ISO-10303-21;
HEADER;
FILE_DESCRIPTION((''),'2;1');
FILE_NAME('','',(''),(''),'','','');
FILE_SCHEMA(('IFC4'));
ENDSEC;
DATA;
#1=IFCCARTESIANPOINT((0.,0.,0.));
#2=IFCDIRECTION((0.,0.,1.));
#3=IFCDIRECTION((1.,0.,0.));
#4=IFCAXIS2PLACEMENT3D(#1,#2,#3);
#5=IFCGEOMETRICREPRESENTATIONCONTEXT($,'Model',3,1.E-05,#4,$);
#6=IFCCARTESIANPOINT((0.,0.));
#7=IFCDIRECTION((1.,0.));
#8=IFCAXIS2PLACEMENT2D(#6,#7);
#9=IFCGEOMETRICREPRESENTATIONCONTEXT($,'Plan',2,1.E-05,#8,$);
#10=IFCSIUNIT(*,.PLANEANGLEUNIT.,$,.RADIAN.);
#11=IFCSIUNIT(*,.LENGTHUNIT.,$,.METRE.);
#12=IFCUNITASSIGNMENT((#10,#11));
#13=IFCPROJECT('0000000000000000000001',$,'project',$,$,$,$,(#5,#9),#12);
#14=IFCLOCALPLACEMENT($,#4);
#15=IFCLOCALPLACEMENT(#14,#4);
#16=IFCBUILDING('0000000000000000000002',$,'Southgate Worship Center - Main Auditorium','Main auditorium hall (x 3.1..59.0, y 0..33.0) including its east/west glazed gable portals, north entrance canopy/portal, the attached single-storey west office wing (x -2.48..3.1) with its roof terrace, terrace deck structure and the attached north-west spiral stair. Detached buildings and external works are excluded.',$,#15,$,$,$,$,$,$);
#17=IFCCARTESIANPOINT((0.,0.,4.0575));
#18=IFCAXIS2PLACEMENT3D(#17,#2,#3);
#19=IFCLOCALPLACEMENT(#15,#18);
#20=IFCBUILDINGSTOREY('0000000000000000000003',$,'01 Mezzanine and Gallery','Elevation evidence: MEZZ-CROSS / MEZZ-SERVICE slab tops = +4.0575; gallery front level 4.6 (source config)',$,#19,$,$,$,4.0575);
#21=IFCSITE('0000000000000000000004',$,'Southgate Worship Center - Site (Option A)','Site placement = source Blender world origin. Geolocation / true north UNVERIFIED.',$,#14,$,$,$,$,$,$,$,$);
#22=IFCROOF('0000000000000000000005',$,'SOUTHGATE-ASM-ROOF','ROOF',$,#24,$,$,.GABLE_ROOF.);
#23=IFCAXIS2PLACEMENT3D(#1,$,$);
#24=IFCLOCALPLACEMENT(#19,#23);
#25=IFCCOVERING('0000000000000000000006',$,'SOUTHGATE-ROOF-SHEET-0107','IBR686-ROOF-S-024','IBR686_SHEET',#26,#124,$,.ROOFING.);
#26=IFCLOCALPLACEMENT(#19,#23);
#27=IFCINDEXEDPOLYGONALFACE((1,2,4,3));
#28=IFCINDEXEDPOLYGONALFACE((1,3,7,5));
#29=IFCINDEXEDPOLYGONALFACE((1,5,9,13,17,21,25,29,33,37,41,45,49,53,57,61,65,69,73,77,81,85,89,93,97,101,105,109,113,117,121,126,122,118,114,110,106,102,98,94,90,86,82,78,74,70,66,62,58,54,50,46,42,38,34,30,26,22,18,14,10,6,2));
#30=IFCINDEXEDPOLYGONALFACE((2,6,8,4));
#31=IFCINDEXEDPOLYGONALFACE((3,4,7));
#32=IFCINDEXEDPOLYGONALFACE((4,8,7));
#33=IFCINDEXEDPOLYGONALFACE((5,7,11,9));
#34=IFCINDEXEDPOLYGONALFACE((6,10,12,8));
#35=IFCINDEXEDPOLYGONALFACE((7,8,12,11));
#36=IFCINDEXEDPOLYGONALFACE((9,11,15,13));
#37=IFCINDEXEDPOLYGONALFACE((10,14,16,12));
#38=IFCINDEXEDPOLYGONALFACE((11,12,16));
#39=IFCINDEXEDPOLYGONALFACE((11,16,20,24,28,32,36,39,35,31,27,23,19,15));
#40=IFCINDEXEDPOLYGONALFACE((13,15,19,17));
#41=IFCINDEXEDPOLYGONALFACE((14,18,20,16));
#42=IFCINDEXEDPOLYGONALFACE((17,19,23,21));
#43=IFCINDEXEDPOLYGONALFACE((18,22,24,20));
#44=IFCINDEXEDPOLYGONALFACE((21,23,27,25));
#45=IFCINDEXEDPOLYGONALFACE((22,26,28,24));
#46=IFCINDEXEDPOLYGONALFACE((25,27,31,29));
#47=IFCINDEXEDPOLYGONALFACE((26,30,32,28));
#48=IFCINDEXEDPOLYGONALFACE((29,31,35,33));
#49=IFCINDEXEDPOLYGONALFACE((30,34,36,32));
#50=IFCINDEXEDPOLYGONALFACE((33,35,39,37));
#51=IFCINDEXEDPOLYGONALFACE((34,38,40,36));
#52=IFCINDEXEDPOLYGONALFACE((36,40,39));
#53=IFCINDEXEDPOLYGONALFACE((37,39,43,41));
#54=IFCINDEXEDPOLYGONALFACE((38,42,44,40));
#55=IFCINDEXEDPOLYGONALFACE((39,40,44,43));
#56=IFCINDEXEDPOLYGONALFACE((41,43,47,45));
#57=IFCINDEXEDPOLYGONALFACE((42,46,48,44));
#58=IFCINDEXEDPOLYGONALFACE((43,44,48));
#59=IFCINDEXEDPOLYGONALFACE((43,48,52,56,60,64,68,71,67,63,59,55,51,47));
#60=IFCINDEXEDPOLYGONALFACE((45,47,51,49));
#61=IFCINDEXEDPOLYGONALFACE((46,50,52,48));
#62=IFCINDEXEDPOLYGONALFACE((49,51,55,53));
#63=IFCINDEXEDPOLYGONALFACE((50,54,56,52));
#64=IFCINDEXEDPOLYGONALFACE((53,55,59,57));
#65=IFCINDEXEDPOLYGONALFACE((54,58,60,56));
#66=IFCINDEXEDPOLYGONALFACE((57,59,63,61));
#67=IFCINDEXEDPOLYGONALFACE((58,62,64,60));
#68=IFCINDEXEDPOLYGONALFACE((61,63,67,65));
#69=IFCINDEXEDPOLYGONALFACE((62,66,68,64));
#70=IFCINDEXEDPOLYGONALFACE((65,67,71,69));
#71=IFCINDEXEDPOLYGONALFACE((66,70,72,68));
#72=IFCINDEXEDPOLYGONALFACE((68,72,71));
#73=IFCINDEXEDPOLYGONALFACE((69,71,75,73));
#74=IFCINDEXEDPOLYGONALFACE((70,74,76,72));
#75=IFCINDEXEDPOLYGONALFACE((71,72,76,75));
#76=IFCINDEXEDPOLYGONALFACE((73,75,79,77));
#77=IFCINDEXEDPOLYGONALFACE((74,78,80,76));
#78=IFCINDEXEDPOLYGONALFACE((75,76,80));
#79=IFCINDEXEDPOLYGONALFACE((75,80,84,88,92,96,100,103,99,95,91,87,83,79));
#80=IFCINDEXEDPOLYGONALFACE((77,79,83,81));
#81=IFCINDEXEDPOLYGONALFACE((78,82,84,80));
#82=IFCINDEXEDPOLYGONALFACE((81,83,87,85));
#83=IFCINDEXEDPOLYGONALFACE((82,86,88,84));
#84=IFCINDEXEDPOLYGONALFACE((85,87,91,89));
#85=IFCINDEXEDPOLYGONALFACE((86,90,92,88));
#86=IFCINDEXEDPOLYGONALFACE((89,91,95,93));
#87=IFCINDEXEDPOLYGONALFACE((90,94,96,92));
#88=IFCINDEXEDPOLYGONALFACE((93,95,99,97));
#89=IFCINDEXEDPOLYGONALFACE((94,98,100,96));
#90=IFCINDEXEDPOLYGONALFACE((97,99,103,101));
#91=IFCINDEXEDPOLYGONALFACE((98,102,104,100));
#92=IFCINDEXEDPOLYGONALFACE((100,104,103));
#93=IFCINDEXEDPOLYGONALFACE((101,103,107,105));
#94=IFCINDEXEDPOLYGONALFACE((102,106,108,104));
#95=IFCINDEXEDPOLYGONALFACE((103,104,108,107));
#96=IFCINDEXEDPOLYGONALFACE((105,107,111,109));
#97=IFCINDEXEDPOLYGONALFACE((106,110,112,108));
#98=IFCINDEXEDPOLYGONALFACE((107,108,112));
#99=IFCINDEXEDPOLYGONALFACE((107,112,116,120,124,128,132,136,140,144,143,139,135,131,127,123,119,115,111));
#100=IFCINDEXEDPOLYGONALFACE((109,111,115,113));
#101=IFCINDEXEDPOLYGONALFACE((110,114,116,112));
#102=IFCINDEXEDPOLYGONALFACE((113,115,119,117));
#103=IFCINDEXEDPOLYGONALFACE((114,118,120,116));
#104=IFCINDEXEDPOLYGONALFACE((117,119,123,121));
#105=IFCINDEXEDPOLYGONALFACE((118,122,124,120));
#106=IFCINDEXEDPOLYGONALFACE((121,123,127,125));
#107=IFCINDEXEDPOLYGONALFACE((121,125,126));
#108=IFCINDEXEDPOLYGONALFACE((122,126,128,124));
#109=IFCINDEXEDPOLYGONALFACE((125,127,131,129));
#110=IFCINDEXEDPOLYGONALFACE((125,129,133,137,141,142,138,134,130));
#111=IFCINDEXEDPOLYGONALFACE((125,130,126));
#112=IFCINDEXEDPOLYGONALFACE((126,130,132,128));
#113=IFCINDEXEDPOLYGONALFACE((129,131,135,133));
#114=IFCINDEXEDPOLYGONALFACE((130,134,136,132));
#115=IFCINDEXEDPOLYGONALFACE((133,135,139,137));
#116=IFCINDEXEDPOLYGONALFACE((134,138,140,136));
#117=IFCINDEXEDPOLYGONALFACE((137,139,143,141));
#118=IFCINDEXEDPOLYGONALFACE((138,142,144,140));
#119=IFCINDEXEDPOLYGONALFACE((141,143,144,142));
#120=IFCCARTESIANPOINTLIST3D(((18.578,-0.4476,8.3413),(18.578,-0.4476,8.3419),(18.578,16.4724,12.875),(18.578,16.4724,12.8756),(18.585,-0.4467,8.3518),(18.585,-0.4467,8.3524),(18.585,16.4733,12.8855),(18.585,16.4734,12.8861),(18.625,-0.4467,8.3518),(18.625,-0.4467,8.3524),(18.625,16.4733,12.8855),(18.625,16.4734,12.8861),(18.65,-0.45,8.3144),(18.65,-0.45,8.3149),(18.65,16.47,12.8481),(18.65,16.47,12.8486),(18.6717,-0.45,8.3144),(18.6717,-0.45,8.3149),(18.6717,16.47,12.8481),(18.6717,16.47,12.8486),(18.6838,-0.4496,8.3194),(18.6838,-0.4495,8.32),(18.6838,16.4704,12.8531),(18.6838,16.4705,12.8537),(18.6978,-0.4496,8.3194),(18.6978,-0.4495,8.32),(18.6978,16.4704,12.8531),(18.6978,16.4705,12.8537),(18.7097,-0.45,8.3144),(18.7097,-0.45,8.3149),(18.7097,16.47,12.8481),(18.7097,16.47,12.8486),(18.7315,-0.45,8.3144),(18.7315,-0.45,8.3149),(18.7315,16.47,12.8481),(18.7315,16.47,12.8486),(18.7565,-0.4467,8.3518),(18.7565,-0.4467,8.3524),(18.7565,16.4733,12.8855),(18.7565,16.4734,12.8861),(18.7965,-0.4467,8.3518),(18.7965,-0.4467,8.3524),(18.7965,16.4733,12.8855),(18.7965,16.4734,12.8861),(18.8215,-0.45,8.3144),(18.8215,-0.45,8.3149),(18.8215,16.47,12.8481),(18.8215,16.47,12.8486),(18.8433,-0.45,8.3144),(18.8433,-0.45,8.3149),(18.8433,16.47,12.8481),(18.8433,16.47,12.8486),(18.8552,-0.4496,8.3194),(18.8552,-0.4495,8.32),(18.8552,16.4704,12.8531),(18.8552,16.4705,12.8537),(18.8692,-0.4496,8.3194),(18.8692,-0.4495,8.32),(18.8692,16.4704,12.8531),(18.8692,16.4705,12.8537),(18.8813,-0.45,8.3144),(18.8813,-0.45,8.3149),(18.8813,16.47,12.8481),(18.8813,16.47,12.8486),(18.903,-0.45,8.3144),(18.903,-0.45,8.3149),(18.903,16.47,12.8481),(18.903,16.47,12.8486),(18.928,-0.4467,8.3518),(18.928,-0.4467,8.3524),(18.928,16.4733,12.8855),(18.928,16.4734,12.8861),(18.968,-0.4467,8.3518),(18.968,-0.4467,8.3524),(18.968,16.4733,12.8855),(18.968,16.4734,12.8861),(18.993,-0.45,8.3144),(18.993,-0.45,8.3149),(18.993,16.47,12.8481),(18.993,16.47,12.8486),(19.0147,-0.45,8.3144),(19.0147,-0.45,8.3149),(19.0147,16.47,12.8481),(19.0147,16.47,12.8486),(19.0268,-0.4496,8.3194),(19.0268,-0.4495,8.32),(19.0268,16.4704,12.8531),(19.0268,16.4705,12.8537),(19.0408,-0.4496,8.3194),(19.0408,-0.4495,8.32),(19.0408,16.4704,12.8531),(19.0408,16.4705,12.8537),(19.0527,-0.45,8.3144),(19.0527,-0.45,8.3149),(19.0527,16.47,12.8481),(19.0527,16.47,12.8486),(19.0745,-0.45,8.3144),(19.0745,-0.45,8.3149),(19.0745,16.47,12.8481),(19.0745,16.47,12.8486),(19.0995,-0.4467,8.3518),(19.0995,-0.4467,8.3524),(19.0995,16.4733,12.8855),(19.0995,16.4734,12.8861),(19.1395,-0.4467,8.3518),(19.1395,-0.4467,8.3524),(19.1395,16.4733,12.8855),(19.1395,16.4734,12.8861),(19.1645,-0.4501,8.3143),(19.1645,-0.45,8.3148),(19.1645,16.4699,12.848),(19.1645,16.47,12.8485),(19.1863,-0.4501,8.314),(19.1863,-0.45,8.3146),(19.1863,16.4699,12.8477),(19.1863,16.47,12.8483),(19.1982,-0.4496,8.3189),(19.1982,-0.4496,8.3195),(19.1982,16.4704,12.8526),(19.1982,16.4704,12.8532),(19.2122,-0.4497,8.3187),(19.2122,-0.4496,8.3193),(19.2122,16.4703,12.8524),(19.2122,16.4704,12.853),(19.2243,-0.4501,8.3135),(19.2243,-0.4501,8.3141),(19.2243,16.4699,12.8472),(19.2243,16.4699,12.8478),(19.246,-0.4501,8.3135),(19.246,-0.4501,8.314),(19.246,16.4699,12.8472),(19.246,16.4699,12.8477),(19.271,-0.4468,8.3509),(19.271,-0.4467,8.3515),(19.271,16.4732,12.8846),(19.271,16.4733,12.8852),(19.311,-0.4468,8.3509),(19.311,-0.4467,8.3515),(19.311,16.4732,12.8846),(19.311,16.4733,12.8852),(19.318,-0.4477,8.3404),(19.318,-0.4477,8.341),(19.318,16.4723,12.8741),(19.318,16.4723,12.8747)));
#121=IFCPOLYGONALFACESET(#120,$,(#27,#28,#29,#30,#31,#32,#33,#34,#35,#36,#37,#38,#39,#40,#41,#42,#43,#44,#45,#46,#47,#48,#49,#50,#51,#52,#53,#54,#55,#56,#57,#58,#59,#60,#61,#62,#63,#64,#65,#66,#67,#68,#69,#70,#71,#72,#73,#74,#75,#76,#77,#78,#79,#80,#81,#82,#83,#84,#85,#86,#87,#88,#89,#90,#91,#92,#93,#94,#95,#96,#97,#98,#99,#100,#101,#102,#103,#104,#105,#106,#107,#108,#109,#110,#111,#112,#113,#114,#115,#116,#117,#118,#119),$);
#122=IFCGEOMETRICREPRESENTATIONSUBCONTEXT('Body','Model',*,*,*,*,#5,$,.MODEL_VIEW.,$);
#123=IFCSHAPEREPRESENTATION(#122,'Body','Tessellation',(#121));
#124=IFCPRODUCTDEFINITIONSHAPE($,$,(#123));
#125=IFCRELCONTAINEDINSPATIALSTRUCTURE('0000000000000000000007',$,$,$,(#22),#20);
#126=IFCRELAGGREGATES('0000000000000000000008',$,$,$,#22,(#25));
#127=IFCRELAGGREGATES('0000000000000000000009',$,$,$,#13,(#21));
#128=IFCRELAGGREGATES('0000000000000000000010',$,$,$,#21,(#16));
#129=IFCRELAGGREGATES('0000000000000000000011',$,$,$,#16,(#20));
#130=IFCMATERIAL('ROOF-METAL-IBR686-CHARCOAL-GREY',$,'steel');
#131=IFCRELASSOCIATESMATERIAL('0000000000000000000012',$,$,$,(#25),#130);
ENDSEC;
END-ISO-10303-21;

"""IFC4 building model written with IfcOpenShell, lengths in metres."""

from ifc_helpers import new_model, si_unit, frame, origin_with_axes, origin_2d_with_axis, place, context, subcontext, project, spatial, indexed_curve, outline, extrude, clip, halfspace, material, element, aggregate, save


model = new_model("IFC4")

# Units and contexts
model_context = context("Model", 3, precision=1e-05, world=origin_with_axes())
plan_context = context("Plan", 2, precision=1e-05, world=origin_2d_with_axis())
body_context = subcontext(model_context, "Body", "Model", "MODEL_VIEW")
ifc_project = project(units=[si_unit("PLANEANGLEUNIT", "RADIAN"), si_unit("LENGTHUNIT", "METRE")], contexts=[model_context, plan_context])

# Site, building, storey
site_placement = place(None, origin_with_axes())
site = spatial("IfcSite", under=ifc_project, at=site_placement, Name="Southgate Worship Center - Site (Option A)", Description="Site placement = source Blender world origin. Geolocation / true north UNVERIFIED.")
building_placement = place(site_placement, origin_with_axes())
building = spatial("IfcBuilding", under=site, at=building_placement, Name="Southgate Worship Center - Main Auditorium", Description="Main auditorium hall (x 3.1..59.0, y 0..33.0) including its east/west glazed gable portals, north entrance canopy/portal, the attached single-storey west office wing (x -2.48..3.1) with its roof terrace, terrace deck structure and the attached north-west spiral stair. Detached buildings and external works are excluded.")
storey_placement = place(building_placement, frame((0.0, 0.0, 4.0575), z_axis=(0.0, 0.0, 1.0), x_axis=(1.0, 0.0, 0.0)))
storey = spatial("IfcBuildingStorey", under=building, at=storey_placement, Name="01 Mezzanine and Gallery", Description="Elevation evidence: MEZZ-CROSS / MEZZ-SERVICE slab tops = +4.0575; gallery front level 4.6 (source config)", Elevation=4.0575)

# Roof, covering
roof_placement = place(storey_placement, origin_with_axes())
roof = element("IfcRoof", 1, at=roof_placement, inside=storey, Name="SOUTHGATE-ASM-ROOF", Description="ROOF", PredefinedType="GABLE_ROOF")
ifc_material_1 = material(Name="ROOF-METAL-IBR686-CHARCOAL-GREY", Category="steel")
covering_1_placement = place(roof_placement, frame((18.578, -0.4501, 8.3135), z_axis=(0.0, 0.0, 1.0), x_axis=(1.0, 0.0, 0.0)))
covering_1 = element("IfcCovering", 2, at=covering_1_placement, material=ifc_material_1, Name="SOUTHGATE-ROOF-SHEET-0107", Description="IBR686-ROOF-S-024", ObjectType="IBR686_SHEET", PredefinedType="ROOFING", context=body_context, shape_type="Clipping", body=[
    clip(clip(extrude(outline(indexed_curve([(0.0, 0.0), (0.025, 0.0353), (0.065, 0.0353), (0.072, 0.0254), (0.072, 0.0259), (0.065, 0.0358), (0.025, 0.0358), (0.0, 0.0005), (-0.0217, 0.0005), (-0.0338, 0.0053), (-0.0478, 0.0053), (-0.0597, 0.0005), (-0.0815, 0.0005), (-0.1065, 0.0358), (-0.1465, 0.0358), (-0.1715, 0.0005), (-0.1933, 0.0005), (-0.2052, 0.0053), (-0.2192, 0.0053), (-0.2313, 0.0005), (-0.253, 0.0005), (-0.278, 0.0358), (-0.318, 0.0358), (-0.343, 0.0005), (-0.3647, 0.0005), (-0.3768, 0.0053), (-0.3908, 0.0053), (-0.4028, 0.0005), (-0.4245, 0.0005), (-0.4495, 0.0358), (-0.4895, 0.0358), (-0.5145, 0.0004), (-0.5363, 0.0002), (-0.5483, 0.0048), (-0.5623, 0.0046), (-0.5743, -0.0003), (-0.596, -0.0004), (-0.621, 0.0349), (-0.661, 0.0349), (-0.668, 0.0251), (-0.668, 0.0246), (-0.661, 0.0344), (-0.621, 0.0344), (-0.596, -0.0009), (-0.5743, -0.0008), (-0.5623, 0.0041), (-0.5483, 0.0043), (-0.5363, -0.0003), (-0.5145, -0.0001), (-0.4895, 0.0353), (-0.4495, 0.0353), (-0.4245, 0.0), (-0.4028, 0.0), (-0.3908, 0.0048), (-0.3768, 0.0048), (-0.3647, 0.0), (-0.343, 0.0), (-0.318, 0.0353), (-0.278, 0.0353), (-0.253, 0.0), (-0.2313, 0.0), (-0.2192, 0.0048), (-0.2052, 0.0048), (-0.1933, 0.0), (-0.1715, 0.0), (-0.1465, 0.0353), (-0.1065, 0.0353), (-0.0815, 0.0), (-0.0597, 0.0), (-0.0478, 0.0048), (-0.0338, 0.0048), (-0.0217, 0.0), (0.0, 0.0)], self_intersect=False)), frame((0.072, -0.0003, 0.0008), z_axis=(0.0, 0.965926, 0.258819), x_axis=(-1.0, 0.0, 0.0)), (0.0, 0.0, 1.0), 17.5303), halfspace(frame((0.37, 0.0012, 0.014), z_axis=(0.0, -0.996022, 0.089113), x_axis=(1.0, 0.0, 0.0)), False)), halfspace(frame((0.37, 16.9212, 4.5477), z_axis=(0.0, 0.996021, -0.089119), x_axis=(-1.0, 0.0, 0.0)), False)),
])
aggregate(roof, [covering_1])

save(model, "model.ifc")
